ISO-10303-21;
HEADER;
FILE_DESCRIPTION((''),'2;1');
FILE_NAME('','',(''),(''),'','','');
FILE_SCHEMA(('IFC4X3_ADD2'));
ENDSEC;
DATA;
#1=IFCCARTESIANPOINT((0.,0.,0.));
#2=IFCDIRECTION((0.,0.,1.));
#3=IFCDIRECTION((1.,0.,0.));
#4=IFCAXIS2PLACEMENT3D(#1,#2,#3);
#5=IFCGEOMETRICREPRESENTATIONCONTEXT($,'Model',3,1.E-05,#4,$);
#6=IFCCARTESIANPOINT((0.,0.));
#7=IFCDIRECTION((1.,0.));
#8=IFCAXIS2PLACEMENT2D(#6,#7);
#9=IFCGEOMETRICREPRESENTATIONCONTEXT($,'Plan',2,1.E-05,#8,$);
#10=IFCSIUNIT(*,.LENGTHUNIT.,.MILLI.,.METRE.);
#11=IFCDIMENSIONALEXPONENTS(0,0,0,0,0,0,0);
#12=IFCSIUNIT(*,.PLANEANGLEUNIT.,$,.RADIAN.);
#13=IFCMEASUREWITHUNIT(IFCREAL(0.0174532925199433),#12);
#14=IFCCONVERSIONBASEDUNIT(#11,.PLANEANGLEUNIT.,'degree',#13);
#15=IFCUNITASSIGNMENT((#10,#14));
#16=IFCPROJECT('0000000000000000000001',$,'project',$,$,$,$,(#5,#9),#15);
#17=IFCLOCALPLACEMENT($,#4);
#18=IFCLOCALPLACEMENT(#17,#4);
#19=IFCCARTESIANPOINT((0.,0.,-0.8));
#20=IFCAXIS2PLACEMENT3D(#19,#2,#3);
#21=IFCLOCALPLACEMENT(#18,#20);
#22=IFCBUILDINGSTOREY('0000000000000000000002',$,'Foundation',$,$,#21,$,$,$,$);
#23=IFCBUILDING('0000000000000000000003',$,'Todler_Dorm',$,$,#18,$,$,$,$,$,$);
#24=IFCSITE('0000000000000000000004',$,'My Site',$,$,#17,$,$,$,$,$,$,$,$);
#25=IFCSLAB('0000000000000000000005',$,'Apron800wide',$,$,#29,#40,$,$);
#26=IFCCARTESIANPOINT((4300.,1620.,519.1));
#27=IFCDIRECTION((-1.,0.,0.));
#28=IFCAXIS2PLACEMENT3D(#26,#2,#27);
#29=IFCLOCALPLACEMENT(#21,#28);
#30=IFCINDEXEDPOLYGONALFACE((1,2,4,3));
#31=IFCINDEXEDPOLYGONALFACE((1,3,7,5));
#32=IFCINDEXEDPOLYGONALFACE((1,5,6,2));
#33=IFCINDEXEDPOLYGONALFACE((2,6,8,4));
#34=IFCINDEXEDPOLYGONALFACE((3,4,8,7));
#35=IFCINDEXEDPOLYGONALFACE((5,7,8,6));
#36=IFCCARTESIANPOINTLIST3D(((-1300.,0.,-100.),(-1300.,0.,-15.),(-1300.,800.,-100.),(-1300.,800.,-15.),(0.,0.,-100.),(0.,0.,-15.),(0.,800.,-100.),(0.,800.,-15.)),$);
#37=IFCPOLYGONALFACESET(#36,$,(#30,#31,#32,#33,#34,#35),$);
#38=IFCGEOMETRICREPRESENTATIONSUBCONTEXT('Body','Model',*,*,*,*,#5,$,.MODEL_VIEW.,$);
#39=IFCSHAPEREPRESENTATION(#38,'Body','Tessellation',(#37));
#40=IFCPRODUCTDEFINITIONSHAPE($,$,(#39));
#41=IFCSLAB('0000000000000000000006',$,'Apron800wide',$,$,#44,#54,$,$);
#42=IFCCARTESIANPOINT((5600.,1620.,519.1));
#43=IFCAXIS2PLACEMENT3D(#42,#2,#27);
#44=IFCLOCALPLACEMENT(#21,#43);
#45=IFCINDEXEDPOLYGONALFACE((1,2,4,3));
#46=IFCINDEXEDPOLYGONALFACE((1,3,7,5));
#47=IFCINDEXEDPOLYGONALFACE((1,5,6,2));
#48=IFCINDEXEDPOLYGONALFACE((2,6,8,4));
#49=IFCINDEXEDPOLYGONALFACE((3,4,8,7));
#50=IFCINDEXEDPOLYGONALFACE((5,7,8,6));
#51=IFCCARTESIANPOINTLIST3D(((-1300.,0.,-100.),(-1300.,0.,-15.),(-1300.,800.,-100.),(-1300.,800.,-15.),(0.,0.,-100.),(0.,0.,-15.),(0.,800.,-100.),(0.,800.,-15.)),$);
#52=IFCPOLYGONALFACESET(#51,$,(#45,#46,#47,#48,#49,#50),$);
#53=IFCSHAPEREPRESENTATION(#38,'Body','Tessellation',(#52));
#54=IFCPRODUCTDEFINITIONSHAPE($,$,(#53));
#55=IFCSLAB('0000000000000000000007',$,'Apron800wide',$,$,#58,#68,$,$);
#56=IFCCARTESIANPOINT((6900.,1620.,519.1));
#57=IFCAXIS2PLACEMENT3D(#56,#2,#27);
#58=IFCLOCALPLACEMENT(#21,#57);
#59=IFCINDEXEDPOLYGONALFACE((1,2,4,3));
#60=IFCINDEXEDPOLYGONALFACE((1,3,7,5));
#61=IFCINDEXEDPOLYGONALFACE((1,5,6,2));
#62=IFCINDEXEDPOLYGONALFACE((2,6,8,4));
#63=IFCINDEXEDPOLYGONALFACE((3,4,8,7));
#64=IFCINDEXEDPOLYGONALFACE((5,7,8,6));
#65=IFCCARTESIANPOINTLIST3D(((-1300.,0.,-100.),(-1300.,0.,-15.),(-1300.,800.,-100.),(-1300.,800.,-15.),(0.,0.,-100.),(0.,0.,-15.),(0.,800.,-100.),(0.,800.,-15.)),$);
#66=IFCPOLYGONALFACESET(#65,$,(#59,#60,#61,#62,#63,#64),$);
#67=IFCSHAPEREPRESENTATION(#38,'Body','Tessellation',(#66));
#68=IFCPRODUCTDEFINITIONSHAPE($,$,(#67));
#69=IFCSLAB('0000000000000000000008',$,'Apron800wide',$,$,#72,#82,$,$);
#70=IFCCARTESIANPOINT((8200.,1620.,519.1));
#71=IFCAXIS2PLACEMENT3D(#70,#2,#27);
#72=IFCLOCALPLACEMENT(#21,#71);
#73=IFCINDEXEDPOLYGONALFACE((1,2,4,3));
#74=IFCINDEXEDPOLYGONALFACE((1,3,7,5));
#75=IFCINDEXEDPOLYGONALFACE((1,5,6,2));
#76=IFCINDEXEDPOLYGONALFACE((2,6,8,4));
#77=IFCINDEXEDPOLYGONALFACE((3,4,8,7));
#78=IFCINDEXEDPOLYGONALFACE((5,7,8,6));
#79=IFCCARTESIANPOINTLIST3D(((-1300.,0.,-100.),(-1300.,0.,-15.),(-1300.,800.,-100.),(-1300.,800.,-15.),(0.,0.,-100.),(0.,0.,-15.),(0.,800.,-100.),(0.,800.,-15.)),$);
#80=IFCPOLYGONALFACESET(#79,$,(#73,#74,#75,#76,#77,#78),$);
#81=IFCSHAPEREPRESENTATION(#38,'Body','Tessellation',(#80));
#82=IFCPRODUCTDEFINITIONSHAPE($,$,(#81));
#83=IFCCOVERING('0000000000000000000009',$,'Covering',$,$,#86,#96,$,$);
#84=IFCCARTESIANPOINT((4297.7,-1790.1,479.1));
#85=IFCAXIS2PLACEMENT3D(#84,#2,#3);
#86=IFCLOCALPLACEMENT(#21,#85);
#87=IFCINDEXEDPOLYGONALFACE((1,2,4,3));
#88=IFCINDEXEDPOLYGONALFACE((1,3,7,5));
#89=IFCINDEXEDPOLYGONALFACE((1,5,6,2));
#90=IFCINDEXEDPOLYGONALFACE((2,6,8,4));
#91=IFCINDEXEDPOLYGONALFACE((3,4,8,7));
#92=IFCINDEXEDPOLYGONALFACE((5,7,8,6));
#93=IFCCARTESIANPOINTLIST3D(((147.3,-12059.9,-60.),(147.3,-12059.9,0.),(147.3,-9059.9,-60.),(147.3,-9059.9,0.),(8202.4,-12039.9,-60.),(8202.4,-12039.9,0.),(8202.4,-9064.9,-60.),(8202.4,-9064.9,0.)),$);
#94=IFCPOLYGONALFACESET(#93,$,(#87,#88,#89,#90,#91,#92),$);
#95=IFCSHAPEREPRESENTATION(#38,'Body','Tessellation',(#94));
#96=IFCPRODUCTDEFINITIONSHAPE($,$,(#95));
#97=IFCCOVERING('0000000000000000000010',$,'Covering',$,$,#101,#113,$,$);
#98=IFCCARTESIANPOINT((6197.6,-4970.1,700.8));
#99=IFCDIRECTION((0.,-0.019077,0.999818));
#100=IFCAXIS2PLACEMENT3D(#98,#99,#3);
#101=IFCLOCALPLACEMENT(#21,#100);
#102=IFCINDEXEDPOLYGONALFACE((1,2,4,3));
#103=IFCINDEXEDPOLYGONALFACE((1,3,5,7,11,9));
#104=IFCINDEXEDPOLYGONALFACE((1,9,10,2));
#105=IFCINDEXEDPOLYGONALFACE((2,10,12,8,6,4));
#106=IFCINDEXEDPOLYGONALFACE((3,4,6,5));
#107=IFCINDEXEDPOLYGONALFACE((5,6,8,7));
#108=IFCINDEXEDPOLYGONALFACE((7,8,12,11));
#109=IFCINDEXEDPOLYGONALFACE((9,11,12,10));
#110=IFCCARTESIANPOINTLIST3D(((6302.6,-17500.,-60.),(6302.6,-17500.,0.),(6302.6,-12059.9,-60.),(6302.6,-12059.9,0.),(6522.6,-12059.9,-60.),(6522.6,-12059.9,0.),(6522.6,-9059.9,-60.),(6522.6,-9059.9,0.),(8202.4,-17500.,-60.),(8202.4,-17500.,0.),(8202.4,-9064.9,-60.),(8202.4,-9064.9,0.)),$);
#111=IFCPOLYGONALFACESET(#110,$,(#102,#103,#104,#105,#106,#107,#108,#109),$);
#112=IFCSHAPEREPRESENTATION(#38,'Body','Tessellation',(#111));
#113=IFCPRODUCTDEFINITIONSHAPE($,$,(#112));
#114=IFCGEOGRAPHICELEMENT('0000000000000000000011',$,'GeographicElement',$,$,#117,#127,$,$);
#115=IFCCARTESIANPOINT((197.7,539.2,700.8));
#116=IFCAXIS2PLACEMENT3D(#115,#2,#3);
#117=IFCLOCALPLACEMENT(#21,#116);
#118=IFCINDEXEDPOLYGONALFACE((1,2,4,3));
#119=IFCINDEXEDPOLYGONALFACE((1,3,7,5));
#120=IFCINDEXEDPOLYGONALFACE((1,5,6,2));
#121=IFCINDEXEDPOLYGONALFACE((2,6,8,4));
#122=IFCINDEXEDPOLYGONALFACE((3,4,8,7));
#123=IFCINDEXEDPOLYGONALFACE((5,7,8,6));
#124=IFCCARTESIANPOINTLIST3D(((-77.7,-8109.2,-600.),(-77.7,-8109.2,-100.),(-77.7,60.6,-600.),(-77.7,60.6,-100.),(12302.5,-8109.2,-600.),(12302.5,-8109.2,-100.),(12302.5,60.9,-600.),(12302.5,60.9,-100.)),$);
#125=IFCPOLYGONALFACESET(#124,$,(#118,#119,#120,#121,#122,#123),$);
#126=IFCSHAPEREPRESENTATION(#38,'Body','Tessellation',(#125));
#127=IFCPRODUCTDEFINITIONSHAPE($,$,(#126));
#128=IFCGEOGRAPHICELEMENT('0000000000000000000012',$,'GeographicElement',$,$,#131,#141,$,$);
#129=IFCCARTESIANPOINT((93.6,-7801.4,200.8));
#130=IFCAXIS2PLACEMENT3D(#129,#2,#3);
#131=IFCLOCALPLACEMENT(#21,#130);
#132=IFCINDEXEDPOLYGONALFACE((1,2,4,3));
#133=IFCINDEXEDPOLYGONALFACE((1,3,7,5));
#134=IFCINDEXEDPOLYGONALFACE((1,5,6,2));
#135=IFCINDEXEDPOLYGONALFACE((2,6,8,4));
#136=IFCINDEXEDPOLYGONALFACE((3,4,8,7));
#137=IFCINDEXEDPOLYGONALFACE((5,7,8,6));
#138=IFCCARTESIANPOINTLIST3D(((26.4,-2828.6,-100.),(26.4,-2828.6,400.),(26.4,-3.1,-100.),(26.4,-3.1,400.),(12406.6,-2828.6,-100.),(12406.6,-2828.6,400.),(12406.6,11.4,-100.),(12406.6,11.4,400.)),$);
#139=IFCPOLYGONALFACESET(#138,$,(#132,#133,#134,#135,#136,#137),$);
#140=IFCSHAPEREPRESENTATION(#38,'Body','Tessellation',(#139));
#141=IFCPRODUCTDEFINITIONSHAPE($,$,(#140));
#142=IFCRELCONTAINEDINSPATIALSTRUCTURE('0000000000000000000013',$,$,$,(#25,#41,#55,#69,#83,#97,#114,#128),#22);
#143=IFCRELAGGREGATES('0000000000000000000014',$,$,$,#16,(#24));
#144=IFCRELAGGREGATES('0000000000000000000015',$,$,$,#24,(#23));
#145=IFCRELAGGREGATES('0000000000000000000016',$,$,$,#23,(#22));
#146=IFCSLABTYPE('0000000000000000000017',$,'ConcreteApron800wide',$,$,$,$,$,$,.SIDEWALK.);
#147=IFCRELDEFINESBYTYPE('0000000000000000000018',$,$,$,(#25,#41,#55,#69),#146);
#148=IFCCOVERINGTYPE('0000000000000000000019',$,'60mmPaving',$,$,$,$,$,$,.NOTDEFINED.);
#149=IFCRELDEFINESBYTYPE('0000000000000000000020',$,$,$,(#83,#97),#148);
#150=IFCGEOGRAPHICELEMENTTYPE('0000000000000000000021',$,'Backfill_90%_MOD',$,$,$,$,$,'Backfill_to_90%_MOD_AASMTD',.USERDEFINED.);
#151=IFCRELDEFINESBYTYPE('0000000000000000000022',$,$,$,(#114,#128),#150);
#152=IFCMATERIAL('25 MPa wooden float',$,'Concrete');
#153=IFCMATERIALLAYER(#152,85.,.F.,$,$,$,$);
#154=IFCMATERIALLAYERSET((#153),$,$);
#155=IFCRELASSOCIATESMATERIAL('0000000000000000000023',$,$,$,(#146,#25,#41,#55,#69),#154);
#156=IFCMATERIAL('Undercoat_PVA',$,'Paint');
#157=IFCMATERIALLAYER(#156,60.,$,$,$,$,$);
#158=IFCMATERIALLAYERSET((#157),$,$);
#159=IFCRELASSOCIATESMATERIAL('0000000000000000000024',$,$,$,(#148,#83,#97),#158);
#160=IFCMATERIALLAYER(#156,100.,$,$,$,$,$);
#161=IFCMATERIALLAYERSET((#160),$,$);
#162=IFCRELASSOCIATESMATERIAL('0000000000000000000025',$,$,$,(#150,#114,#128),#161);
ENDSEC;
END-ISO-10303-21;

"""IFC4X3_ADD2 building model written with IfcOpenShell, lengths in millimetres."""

from ifc_helpers import new_model, entity, si_unit, converted_unit, frame, origin_with_axes, origin_2d_with_axis, place, context, subcontext, project, spatial, indexed_curve, outline, extrude, material, layer, layer_set, layer_usage, type_object, element, save


model = new_model("IFC4X3_ADD2")

# Units and contexts
model_context = context("Model", 3, precision=1e-05, world=origin_with_axes())
plan_context = context("Plan", 2, precision=1e-05, world=origin_2d_with_axis())
body_context = subcontext(model_context, "Body", "Model", "MODEL_VIEW")
ifc_project = project(units=[si_unit("LENGTHUNIT", "METRE", prefix="MILLI"), converted_unit("PLANEANGLEUNIT", "degree", entity("IfcReal", 0.0174532925199433), si_unit("PLANEANGLEUNIT", "RADIAN"), dimensions=[0, 0, 0, 0, 0, 0, 0])], contexts=[model_context, plan_context])

# Site, building, storey
site_placement = place(None, origin_with_axes())
site = spatial("IfcSite", under=ifc_project, at=site_placement, Name="My Site")
building_placement = place(site_placement, origin_with_axes())
building = spatial("IfcBuilding", under=site, at=building_placement, Name="Todler_Dorm")
storey_placement = place(building_placement, frame((0.0, 0.0, -0.8), z_axis=(0.0, 0.0, 1.0), x_axis=(1.0, 0.0, 0.0)))
storey = spatial("IfcBuildingStorey", under=building, at=storey_placement, Name="Foundation")

# Shared definitions
ifc_material_1 = material(Name="Undercoat_PVA", Category="Paint")

# Slabs
ifc_material_2 = material(Name="25 MPa wooden float", Category="Concrete")
ifc_layer_1 = layer(ifc_material_2, 85.0, ventilated=False)
ifc_layer_set_1 = layer_set([ifc_layer_1])
slab_type_1 = type_object("IfcSlabType", Name="ConcreteApron800wide", PredefinedType="SIDEWALK", material=ifc_layer_set_1)
ifc_layer_usage_1 = layer_usage(ifc_layer_set_1, "AXIS3", "POSITIVE", -100.0)
slab_1_placement = place(storey_placement, frame((4300.0, 1620.0, 519.1), z_axis=(0.0, 0.0, 1.0), x_axis=(-1.0, 0.0, 0.0)))
element("IfcSlab", 1, at=slab_1_placement, inside=storey, type_object=slab_type_1, material=ifc_layer_usage_1, Name="Apron800wide", context=body_context, shape_type="SweptSolid", body=[
    extrude(outline(indexed_curve([(0.0, 0.0), (0.0, 800.0), (-1300.0, 800.0), (-1300.0, 0.0), (0.0, 0.0)])), frame((0.0, 0.0, -100.0), z_axis=(0.0, 0.0, 1.0), x_axis=(1.0, 0.0, 0.0)), (0.0, 0.0, 1.0), 85.0),
])
ifc_layer_usage_2 = layer_usage(ifc_layer_set_1, "AXIS3", "POSITIVE", -100.0)
slab_2_placement = place(storey_placement, frame((5600.0, 1620.0, 519.1), z_axis=(0.0, 0.0, 1.0), x_axis=(-1.0, 0.0, 0.0)))
element("IfcSlab", 2, at=slab_2_placement, inside=storey, type_object=slab_type_1, material=ifc_layer_usage_2, Name="Apron800wide", context=body_context, shape_type="SweptSolid", body=[
    extrude(outline(indexed_curve([(0.0, 0.0), (0.0, 800.0), (-1300.0, 800.0), (-1300.0, 0.0), (0.0, 0.0)])), frame((0.0, 0.0, -100.0), z_axis=(0.0, 0.0, 1.0), x_axis=(1.0, 0.0, 0.0)), (0.0, 0.0, 1.0), 85.0),
])
ifc_layer_usage_3 = layer_usage(ifc_layer_set_1, "AXIS3", "POSITIVE", -100.0)
slab_3_placement = place(storey_placement, frame((6900.0, 1620.0, 519.1), z_axis=(0.0, 0.0, 1.0), x_axis=(-1.0, 0.0, 0.0)))
element("IfcSlab", 3, at=slab_3_placement, inside=storey, type_object=slab_type_1, material=ifc_layer_usage_3, Name="Apron800wide", context=body_context, shape_type="SweptSolid", body=[
    extrude(outline(indexed_curve([(0.0, 0.0), (0.0, 800.0), (-1300.0, 800.0), (-1300.0, 0.0), (0.0, 0.0)])), frame((0.0, 0.0, -100.0), z_axis=(0.0, 0.0, 1.0), x_axis=(1.0, 0.0, 0.0)), (0.0, 0.0, 1.0), 85.0),
])
ifc_layer_usage_4 = layer_usage(ifc_layer_set_1, "AXIS3", "POSITIVE", -100.0)
slab_4_placement = place(storey_placement, frame((8200.0, 1620.0, 519.1), z_axis=(0.0, 0.0, 1.0), x_axis=(-1.0, 0.0, 0.0)))
element("IfcSlab", 4, at=slab_4_placement, inside=storey, type_object=slab_type_1, material=ifc_layer_usage_4, Name="Apron800wide", context=body_context, shape_type="SweptSolid", body=[
    extrude(outline(indexed_curve([(0.0, 0.0), (0.0, 800.0), (-1300.0, 800.0), (-1300.0, 0.0), (0.0, 0.0)])), frame((0.0, 0.0, -100.0), z_axis=(0.0, 0.0, 1.0), x_axis=(1.0, 0.0, 0.0)), (0.0, 0.0, 1.0), 85.0),
])

# Coverings
ifc_layer_2 = layer(ifc_material_1, 60.0)
ifc_layer_set_2 = layer_set([ifc_layer_2])
covering_type_1 = type_object("IfcCoveringType", Name="60mmPaving", PredefinedType="NOTDEFINED", material=ifc_layer_set_2)
ifc_layer_usage_5 = layer_usage(ifc_layer_set_2, "AXIS3", "POSITIVE", -60.0)
covering_1_placement = place(storey_placement, frame((4297.7, -1790.1, 479.1), z_axis=(0.0, 0.0, 1.0), x_axis=(1.0, 0.0, 0.0)))
element("IfcCovering", 5, at=covering_1_placement, inside=storey, type_object=covering_type_1, material=ifc_layer_usage_5, Name="Covering", context=body_context, shape_type="SweptSolid", body=[
    extrude(outline(indexed_curve([(147.3, -9059.9), (147.3, -12059.9), (8202.4, -12039.9), (8202.4, -9064.9), (147.3, -9059.9)])), frame((0.0, 0.0, -60.0), z_axis=(0.0, 0.0, 1.0), x_axis=(1.0, 0.0, 0.0)), (0.0, 0.0, 1.0), 60.0),
])
ifc_layer_usage_6 = layer_usage(ifc_layer_set_2, "AXIS3", "POSITIVE", -60.0)
covering_2_placement = place(storey_placement, frame((6197.6, -4970.1, 700.8), z_axis=(0.0, -0.019077, 0.999818), x_axis=(1.0, 0.0, 0.0)))
element("IfcCovering", 6, at=covering_2_placement, inside=storey, type_object=covering_type_1, material=ifc_layer_usage_6, Name="Covering", context=body_context, shape_type="SweptSolid", body=[
    extrude(outline(indexed_curve([(6522.6, -12059.9), (6302.6, -12059.9), (6302.6, -17500.0), (8202.4, -17500.0), (8202.4, -9064.9), (6522.6, -9059.9), (6522.6, -12059.9)])), frame((0.0, 0.0, -60.0), z_axis=(0.0, 0.0, 1.0), x_axis=(1.0, 0.0, 0.0)), (0.0, 0.0, 1.0), 60.0),
])

# Geographic elements
ifc_layer_3 = layer(ifc_material_1, 100.0)
ifc_layer_set_3 = layer_set([ifc_layer_3])
ifc_layer_usage_7 = layer_usage(ifc_layer_set_3, "AXIS3", "POSITIVE", -100.0)
geographic_element_type = type_object("IfcGeographicElementType", Name="Backfill_90%_MOD", ElementType="Backfill_to_90%_MOD_AASMTD", PredefinedType="USERDEFINED", material=ifc_layer_set_3)
geographic_element_1_placement = place(storey_placement, frame((197.7, 539.2, 700.8), z_axis=(0.0, 0.0, 1.0), x_axis=(1.0, 0.0, 0.0)))
element("IfcGeographicElement", 7, at=geographic_element_1_placement, inside=storey, type_object=geographic_element_type, material=ifc_layer_usage_7, Name="GeographicElement", context=body_context, shape_type="SweptSolid", body=[
    extrude(outline(indexed_curve([(-77.7, -8109.2), (12302.5, -8109.2), (12302.5, 60.9), (-77.7, 60.6), (-77.7, -8109.2)])), frame((0.0, 0.0, -600.0), z_axis=(0.0, 0.0, 1.0), x_axis=(1.0, 0.0, 0.0)), (0.0, 0.0, 1.0), 500.0),
])
ifc_layer_usage_8 = layer_usage(ifc_layer_set_3, "AXIS3", "POSITIVE", -100.0)
geographic_element_2_placement = place(storey_placement, frame((93.6, -7801.4, 200.8), z_axis=(0.0, 0.0, 1.0), x_axis=(1.0, 0.0, 0.0)))
element("IfcGeographicElement", 8, at=geographic_element_2_placement, inside=storey, type_object=geographic_element_type, material=ifc_layer_usage_8, Name="GeographicElement", context=body_context, shape_type="SweptSolid", body=[
    extrude(outline(indexed_curve([(26.4, -2828.6), (12406.6, -2828.6), (12406.6, 11.4), (26.4, -3.1), (26.4, -2828.6)])), frame((0.0, 0.0, -100.0), z_axis=(0.0, 0.0, 1.0), x_axis=(1.0, 0.0, 0.0)), (0.0, 0.0, 1.0), 500.0),
])

save(model, "model.ifc")
